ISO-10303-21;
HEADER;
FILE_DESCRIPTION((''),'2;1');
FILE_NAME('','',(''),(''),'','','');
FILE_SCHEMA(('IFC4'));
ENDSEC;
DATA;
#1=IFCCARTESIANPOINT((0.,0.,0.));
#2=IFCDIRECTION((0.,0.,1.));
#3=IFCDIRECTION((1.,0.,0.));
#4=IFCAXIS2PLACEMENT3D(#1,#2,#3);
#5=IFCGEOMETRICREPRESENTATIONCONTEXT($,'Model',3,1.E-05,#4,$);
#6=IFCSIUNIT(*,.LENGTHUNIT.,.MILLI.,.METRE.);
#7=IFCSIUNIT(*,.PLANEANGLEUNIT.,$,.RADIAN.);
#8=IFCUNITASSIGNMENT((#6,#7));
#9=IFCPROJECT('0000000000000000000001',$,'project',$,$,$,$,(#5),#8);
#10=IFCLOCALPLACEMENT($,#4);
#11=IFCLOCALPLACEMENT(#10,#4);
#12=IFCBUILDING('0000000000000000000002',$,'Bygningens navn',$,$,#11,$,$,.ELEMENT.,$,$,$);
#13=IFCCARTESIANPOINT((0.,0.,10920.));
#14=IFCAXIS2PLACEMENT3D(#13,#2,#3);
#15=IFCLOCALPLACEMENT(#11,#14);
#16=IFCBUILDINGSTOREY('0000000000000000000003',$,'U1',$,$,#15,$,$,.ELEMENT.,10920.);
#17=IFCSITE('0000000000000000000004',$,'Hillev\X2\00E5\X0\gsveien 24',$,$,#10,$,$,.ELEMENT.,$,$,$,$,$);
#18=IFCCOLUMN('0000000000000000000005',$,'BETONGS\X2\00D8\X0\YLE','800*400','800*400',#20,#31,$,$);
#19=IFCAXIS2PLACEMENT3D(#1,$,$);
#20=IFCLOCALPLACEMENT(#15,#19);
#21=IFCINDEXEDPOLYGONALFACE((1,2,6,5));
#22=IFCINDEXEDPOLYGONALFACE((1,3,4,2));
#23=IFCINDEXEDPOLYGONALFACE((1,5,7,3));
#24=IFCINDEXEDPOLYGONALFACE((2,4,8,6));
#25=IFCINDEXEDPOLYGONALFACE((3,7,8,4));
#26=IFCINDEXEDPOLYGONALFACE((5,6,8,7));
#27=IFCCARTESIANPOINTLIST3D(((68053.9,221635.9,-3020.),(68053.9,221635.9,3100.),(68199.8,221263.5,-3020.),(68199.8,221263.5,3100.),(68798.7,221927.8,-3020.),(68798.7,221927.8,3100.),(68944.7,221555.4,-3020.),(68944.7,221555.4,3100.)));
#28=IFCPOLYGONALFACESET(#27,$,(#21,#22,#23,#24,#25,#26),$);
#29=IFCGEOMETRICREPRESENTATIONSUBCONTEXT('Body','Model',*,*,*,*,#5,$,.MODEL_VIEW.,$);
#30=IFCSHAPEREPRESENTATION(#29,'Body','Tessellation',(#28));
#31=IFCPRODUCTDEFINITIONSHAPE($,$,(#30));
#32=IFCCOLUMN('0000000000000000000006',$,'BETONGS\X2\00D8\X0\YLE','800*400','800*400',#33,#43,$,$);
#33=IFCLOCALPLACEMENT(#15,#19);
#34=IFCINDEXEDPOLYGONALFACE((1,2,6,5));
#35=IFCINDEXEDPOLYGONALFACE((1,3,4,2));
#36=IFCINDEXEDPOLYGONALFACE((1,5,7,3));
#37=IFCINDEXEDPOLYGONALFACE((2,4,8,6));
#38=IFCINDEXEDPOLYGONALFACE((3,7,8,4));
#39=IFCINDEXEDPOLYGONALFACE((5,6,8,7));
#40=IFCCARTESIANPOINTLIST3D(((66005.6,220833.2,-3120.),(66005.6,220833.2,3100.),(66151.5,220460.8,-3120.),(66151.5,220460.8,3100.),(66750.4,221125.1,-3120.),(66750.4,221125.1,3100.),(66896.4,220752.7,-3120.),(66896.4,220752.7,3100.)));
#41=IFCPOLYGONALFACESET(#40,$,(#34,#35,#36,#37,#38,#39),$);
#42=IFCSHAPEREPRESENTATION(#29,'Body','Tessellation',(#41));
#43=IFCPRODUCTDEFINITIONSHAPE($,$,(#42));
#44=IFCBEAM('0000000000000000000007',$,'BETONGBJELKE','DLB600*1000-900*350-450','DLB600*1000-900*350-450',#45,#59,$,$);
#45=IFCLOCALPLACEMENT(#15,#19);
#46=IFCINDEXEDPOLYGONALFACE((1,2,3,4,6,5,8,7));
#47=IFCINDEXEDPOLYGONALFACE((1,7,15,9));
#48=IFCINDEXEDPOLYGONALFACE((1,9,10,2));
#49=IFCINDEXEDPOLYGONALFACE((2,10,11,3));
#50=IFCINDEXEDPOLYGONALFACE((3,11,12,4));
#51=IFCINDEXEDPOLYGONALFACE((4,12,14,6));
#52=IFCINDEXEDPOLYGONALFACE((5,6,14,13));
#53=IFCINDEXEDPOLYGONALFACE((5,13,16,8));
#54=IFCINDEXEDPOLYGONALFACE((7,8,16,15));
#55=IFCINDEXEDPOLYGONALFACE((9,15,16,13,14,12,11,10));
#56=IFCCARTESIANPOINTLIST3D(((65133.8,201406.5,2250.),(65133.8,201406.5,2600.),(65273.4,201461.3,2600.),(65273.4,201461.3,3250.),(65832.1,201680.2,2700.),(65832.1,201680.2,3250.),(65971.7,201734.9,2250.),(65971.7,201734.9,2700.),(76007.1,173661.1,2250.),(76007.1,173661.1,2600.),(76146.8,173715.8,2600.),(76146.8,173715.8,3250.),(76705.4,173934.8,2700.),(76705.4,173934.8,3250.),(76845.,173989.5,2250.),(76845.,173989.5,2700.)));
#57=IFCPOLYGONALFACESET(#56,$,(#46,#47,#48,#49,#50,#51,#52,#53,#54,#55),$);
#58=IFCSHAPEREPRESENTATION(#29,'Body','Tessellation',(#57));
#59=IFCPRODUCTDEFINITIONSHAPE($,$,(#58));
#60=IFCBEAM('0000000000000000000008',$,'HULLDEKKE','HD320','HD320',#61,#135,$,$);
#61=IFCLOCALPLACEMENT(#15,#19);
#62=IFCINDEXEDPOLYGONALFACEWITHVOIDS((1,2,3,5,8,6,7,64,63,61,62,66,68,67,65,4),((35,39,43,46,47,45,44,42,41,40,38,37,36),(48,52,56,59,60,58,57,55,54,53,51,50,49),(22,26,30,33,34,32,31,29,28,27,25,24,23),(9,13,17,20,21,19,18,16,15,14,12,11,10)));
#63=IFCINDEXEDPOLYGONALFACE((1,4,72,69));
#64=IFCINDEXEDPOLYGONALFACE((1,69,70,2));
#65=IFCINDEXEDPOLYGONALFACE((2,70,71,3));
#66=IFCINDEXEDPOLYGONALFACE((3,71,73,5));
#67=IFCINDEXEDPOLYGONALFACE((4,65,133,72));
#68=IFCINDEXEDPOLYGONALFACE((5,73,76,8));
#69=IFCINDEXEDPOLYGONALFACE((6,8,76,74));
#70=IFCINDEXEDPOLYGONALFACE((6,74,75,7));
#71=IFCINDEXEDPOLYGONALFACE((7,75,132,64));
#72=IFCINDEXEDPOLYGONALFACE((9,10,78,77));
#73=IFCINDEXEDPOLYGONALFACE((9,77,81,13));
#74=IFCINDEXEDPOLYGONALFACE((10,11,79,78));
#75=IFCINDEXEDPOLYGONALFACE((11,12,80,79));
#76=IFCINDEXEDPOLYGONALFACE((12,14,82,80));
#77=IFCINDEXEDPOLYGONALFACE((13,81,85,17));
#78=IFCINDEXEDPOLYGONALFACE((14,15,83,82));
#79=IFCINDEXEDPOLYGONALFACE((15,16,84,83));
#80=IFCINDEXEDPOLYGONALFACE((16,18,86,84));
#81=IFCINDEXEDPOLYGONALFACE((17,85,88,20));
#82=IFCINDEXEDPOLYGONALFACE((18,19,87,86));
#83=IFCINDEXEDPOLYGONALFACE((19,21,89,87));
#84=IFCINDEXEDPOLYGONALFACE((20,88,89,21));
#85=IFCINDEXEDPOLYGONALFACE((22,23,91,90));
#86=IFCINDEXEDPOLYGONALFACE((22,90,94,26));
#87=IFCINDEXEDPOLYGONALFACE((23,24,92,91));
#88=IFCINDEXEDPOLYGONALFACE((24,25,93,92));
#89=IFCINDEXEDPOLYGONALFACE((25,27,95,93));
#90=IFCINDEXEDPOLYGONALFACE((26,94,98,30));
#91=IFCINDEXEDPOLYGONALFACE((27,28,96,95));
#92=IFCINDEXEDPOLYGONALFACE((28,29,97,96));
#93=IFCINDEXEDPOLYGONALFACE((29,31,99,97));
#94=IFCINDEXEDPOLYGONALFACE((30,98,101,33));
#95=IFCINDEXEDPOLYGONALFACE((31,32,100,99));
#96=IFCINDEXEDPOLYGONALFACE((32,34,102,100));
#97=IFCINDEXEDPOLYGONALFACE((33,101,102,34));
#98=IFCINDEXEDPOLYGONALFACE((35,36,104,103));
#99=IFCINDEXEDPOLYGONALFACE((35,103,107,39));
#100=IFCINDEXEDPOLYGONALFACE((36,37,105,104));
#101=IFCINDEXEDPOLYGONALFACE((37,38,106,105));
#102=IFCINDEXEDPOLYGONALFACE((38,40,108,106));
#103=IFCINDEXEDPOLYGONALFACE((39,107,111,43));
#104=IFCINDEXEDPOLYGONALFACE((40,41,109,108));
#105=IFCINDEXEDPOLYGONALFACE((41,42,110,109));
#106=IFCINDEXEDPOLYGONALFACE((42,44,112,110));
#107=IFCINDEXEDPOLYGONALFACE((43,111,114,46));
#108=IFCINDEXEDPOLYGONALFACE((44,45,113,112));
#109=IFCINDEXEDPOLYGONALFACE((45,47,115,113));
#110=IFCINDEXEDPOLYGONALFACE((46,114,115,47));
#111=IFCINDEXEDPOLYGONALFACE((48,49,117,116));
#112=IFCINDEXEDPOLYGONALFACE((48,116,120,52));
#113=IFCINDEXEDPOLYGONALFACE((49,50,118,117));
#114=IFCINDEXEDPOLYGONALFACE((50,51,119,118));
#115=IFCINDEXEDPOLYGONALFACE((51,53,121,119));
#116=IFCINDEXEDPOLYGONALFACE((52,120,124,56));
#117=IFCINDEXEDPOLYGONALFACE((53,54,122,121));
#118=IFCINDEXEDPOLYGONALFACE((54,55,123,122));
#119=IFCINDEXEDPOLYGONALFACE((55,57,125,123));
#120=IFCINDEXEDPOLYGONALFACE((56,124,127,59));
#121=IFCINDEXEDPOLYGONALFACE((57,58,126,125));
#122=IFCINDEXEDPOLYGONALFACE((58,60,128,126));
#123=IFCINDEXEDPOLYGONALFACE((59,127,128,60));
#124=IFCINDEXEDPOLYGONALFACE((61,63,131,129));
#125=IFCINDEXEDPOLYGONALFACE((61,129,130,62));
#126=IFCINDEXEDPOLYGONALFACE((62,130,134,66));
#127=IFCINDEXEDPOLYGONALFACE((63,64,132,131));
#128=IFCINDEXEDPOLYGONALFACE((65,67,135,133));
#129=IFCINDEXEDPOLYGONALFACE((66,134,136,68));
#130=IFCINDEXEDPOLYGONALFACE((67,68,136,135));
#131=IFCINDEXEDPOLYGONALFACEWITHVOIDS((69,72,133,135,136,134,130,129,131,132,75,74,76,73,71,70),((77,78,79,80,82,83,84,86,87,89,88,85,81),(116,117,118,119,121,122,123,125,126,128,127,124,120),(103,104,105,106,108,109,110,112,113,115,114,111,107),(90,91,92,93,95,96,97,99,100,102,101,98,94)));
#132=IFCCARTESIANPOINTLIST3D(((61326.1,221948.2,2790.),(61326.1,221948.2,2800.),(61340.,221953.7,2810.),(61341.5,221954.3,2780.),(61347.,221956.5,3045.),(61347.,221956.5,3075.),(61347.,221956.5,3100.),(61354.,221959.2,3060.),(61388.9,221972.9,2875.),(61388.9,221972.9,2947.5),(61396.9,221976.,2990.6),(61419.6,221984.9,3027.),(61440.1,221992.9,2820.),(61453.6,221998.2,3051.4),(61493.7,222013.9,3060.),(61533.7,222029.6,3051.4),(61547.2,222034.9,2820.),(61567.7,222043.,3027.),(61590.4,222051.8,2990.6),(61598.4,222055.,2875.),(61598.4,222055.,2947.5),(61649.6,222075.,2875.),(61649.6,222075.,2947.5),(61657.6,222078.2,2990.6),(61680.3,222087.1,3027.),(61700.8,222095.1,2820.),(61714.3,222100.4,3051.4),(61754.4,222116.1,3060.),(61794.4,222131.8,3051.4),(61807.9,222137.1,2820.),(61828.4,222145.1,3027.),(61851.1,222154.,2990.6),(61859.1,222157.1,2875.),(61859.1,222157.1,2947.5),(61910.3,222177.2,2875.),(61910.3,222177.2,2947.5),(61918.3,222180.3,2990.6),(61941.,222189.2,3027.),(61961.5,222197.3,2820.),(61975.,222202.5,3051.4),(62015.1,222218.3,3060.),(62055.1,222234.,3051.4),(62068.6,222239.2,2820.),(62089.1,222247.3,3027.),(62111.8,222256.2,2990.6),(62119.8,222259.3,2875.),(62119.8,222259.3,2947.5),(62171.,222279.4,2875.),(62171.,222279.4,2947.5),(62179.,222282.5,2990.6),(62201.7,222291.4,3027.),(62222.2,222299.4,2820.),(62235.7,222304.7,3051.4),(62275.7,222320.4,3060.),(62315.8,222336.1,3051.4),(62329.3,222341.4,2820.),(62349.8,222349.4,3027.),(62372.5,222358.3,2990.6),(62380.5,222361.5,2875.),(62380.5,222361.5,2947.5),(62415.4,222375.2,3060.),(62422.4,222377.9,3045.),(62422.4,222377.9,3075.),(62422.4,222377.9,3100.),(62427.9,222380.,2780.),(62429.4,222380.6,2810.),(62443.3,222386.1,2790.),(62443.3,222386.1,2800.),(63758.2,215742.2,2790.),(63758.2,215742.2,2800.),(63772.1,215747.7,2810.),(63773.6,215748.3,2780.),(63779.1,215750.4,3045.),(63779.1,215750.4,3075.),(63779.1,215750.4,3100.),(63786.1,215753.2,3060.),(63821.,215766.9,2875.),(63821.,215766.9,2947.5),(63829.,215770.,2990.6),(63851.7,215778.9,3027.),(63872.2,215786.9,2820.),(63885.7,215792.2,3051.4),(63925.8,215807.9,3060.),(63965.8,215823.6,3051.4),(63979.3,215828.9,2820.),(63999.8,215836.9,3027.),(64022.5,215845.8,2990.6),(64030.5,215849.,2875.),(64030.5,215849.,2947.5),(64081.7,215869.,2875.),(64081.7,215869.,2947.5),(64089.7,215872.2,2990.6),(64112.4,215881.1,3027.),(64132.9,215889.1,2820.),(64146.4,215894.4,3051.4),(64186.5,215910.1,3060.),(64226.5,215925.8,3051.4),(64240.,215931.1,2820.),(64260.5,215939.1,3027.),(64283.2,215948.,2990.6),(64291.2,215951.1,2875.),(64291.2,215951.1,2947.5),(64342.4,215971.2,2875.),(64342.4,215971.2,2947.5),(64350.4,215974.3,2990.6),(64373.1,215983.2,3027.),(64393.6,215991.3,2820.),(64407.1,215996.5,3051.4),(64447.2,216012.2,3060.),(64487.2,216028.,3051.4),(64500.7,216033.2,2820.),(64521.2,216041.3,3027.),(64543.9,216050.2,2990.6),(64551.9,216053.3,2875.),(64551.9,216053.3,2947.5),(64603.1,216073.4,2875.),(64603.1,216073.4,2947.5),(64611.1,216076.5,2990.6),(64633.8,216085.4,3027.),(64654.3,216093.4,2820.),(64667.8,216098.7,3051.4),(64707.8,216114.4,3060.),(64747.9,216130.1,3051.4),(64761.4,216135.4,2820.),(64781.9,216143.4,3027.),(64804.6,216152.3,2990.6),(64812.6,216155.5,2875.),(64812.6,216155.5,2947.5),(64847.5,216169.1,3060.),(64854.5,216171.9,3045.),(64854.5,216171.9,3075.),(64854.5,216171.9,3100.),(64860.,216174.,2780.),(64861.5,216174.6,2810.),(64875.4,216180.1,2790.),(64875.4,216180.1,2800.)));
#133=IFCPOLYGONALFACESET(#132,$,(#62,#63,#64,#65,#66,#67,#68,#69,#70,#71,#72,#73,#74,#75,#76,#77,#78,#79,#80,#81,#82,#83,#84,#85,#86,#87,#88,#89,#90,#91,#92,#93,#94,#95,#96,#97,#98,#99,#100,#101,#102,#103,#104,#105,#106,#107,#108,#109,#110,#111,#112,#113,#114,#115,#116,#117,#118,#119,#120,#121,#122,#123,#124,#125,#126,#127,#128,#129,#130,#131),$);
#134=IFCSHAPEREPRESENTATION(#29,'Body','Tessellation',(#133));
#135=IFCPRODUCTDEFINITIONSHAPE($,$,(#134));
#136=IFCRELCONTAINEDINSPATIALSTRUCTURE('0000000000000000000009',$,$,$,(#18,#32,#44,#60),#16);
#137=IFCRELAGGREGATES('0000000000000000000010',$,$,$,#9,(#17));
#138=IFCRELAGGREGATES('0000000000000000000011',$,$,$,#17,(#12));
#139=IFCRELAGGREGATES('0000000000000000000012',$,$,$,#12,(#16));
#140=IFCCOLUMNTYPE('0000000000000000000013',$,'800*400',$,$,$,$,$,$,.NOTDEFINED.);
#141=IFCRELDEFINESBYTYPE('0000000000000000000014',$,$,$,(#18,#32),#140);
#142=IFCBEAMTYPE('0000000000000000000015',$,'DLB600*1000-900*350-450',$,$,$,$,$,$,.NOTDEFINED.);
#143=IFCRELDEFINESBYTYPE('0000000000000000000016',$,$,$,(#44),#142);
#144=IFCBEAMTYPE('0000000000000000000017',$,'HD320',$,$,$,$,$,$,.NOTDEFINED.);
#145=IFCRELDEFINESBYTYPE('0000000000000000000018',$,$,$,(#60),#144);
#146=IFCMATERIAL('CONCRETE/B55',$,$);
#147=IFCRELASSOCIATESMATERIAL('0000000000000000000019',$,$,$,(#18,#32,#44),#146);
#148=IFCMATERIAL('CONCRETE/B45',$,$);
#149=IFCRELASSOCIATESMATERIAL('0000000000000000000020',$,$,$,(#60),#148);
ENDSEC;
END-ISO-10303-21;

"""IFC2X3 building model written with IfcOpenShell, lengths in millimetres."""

from ifc_helpers import new_model, si_unit, frame, frame_2d, origin_with_axes, place, context, subcontext, project, spatial, polyline, rectangle, outline, extrude, material, type_object, element, save


model = new_model("IFC2X3")

# Units and contexts
model_context = context("Model", 3, precision=1e-05, world=origin_with_axes())
body_context = subcontext(model_context, "Body", "Model", "MODEL_VIEW")
ifc_project = project(units=[si_unit("LENGTHUNIT", "METRE", prefix="MILLI"), si_unit("PLANEANGLEUNIT", "RADIAN")], contexts=[model_context])

# Site, building, storey
site_placement = place(None, origin_with_axes())
site = spatial("IfcSite", under=ifc_project, at=site_placement, Name="Hillevågsveien 24", CompositionType="ELEMENT")
building_placement = place(site_placement, origin_with_axes())
building = spatial("IfcBuilding", under=site, at=building_placement, Name="Bygningens navn", CompositionType="ELEMENT")
storey_placement = place(building_placement, frame((0.0, 0.0, 10920.0), z_axis=(0.0, 0.0, 1.0), x_axis=(1.0, 0.0, 0.0)))
storey = spatial("IfcBuildingStorey", under=building, at=storey_placement, Name="U1", CompositionType="ELEMENT", Elevation=10920.0)

# Columns
ifc_material_1 = material(Name="CONCRETE/B55")
column_type = type_object("IfcColumnType", Name="800*400", PredefinedType="NOTDEFINED")
column_1_placement = place(storey_placement, frame((68499.3, 221595.6, -3020.0), z_axis=(0.0, 0.0, 1.0), x_axis=(-0.931056, -0.364877, 0.0)))
element("IfcColumn", 1, at=column_1_placement, inside=storey, type_object=column_type, material=ifc_material_1, Name="BETONGSØYLE", Description="800*400", ObjectType="800*400", context=body_context, shape_type="SweptSolid", body=[
    extrude(rectangle(XDim=400.0, YDim=800.0, at=frame_2d((0.0, 0.0), x_axis=(1.0, 0.0))), frame((0.0, 0.0, 6120.0), z_axis=(0.0, 0.0, -1.0), x_axis=(0.0, 1.0, 0.0)), (0.0, 0.0, 1.0), 6120.0),
])
column_2_placement = place(storey_placement, frame((66451.0, 220792.9, -3120.0), z_axis=(0.0, 0.0, 1.0), x_axis=(-0.931056, -0.364877, 0.0)))
element("IfcColumn", 2, at=column_2_placement, inside=storey, type_object=column_type, material=ifc_material_1, Name="BETONGSØYLE", Description="800*400", ObjectType="800*400", context=body_context, shape_type="SweptSolid", body=[
    extrude(rectangle(XDim=400.0, YDim=800.0, at=frame_2d((0.0, 0.0), x_axis=(1.0, 0.0))), frame((0.0, 0.0, 6220.0), z_axis=(0.0, 0.0, -1.0), x_axis=(0.0, 1.0, 0.0)), (0.0, 0.0, 1.0), 6220.0),
])

# Beams
beam_type_1 = type_object("IfcBeamType", Name="DLB600*1000-900*350-450", PredefinedType="NOTDEFINED")
beam_1_placement = place(storey_placement, frame((65552.8, 201570.7, 2750.0), z_axis=(0.0, 0.0, 1.0), x_axis=(0.364877, -0.931056, 0.0)))
element("IfcBeam", 3, at=beam_1_placement, inside=storey, type_object=beam_type_1, material=ifc_material_1, Name="BETONGBJELKE", Description="DLB600*1000-900*350-450", ObjectType="DLB600*1000-900*350-450", context=body_context, shape_type="SweptSolid", body=[
    extrude(outline(polyline([(450.0, -500.0), (-450.0, -500.0), (-450.0, -50.0), (-300.0, -50.0), (-300.0, 500.0), (300.0, 500.0), (300.0, -150.0), (450.0, -150.0), (450.0, -500.0)])), frame((29800.0, 0.0, 0.0), z_axis=(-1.0, 0.0, 0.0), x_axis=(0.0, -1.0, 0.0)), (0.0, 0.0, 1.0), 29800.0),
])
ifc_material_2 = material(Name="CONCRETE/B45")
beam_type_2 = type_object("IfcBeamType", Name="HD320", PredefinedType="NOTDEFINED")
beam_2_placement = place(storey_placement, frame((64316.8, 215961.2, 2940.0), z_axis=(0.0, 0.0, 1.0), x_axis=(-0.364876, 0.931056, 0.0)))
element("IfcBeam", 4, at=beam_2_placement, inside=storey, type_object=beam_type_2, material=ifc_material_2, Name="HULLDEKKE", Description="HD320", ObjectType="HD320", context=body_context, shape_type="SweptSolid", body=[
    extrude(outline(polyline([(577.5, 105.0), (585.0, -130.0), (600.0, -140.0), (600.0, -150.0), (583.4, -160.0), (-583.4, -160.0), (-600.0, -150.0), (-600.0, -140.0), (-585.0, -130.0), (-577.5, 105.0), (-570.0, 120.0), (-577.5, 135.0), (-577.5, 160.0), (577.5, 160.0), (577.5, 135.0), (570.0, 120.0), (577.5, 105.0)]), holes=[polyline([(477.5, -120.0), (532.5, -65.0), (532.5, 7.5), (523.9, 50.6), (499.5, 87.0), (463.1, 111.4), (420.0, 120.0), (376.9, 111.4), (340.5, 87.0), (316.1, 50.6), (307.5, 7.5), (307.5, -65.0), (362.5, -120.0), (477.5, -120.0)]), polyline([(197.5, -120.0), (252.5, -65.0), (252.5, 7.5), (243.9, 50.6), (219.5, 87.0), (183.1, 111.4), (140.0, 120.0), (96.9, 111.4), (60.5, 87.0), (36.1, 50.6), (27.5, 7.5), (27.5, -65.0), (82.5, -120.0), (197.5, -120.0)]), polyline([(-82.5, -120.0), (-27.5, -65.0), (-27.5, 7.5), (-36.1, 50.6), (-60.5, 87.0), (-96.9, 111.4), (-140.0, 120.0), (-183.1, 111.4), (-219.5, 87.0), (-243.9, 50.6), (-252.5, 7.5), (-252.5, -65.0), (-197.5, -120.0), (-82.5, -120.0)]), polyline([(-362.5, -120.0), (-307.5, -65.0), (-307.5, 7.5), (-316.1, 50.6), (-340.5, 87.0), (-376.9, 111.4), (-420.0, 120.0), (-463.1, 111.4), (-499.5, 87.0), (-523.9, 50.6), (-532.5, 7.5), (-532.5, -65.0), (-477.5, -120.0), (-362.5, -120.0)])]), frame((6665.6, 0.0, 0.0), z_axis=(-1.0, 0.0, 0.0), x_axis=(0.0, -1.0, 0.0)), (0.0, 0.0, 1.0), 6665.6),
])

save(model, "model.ifc")
